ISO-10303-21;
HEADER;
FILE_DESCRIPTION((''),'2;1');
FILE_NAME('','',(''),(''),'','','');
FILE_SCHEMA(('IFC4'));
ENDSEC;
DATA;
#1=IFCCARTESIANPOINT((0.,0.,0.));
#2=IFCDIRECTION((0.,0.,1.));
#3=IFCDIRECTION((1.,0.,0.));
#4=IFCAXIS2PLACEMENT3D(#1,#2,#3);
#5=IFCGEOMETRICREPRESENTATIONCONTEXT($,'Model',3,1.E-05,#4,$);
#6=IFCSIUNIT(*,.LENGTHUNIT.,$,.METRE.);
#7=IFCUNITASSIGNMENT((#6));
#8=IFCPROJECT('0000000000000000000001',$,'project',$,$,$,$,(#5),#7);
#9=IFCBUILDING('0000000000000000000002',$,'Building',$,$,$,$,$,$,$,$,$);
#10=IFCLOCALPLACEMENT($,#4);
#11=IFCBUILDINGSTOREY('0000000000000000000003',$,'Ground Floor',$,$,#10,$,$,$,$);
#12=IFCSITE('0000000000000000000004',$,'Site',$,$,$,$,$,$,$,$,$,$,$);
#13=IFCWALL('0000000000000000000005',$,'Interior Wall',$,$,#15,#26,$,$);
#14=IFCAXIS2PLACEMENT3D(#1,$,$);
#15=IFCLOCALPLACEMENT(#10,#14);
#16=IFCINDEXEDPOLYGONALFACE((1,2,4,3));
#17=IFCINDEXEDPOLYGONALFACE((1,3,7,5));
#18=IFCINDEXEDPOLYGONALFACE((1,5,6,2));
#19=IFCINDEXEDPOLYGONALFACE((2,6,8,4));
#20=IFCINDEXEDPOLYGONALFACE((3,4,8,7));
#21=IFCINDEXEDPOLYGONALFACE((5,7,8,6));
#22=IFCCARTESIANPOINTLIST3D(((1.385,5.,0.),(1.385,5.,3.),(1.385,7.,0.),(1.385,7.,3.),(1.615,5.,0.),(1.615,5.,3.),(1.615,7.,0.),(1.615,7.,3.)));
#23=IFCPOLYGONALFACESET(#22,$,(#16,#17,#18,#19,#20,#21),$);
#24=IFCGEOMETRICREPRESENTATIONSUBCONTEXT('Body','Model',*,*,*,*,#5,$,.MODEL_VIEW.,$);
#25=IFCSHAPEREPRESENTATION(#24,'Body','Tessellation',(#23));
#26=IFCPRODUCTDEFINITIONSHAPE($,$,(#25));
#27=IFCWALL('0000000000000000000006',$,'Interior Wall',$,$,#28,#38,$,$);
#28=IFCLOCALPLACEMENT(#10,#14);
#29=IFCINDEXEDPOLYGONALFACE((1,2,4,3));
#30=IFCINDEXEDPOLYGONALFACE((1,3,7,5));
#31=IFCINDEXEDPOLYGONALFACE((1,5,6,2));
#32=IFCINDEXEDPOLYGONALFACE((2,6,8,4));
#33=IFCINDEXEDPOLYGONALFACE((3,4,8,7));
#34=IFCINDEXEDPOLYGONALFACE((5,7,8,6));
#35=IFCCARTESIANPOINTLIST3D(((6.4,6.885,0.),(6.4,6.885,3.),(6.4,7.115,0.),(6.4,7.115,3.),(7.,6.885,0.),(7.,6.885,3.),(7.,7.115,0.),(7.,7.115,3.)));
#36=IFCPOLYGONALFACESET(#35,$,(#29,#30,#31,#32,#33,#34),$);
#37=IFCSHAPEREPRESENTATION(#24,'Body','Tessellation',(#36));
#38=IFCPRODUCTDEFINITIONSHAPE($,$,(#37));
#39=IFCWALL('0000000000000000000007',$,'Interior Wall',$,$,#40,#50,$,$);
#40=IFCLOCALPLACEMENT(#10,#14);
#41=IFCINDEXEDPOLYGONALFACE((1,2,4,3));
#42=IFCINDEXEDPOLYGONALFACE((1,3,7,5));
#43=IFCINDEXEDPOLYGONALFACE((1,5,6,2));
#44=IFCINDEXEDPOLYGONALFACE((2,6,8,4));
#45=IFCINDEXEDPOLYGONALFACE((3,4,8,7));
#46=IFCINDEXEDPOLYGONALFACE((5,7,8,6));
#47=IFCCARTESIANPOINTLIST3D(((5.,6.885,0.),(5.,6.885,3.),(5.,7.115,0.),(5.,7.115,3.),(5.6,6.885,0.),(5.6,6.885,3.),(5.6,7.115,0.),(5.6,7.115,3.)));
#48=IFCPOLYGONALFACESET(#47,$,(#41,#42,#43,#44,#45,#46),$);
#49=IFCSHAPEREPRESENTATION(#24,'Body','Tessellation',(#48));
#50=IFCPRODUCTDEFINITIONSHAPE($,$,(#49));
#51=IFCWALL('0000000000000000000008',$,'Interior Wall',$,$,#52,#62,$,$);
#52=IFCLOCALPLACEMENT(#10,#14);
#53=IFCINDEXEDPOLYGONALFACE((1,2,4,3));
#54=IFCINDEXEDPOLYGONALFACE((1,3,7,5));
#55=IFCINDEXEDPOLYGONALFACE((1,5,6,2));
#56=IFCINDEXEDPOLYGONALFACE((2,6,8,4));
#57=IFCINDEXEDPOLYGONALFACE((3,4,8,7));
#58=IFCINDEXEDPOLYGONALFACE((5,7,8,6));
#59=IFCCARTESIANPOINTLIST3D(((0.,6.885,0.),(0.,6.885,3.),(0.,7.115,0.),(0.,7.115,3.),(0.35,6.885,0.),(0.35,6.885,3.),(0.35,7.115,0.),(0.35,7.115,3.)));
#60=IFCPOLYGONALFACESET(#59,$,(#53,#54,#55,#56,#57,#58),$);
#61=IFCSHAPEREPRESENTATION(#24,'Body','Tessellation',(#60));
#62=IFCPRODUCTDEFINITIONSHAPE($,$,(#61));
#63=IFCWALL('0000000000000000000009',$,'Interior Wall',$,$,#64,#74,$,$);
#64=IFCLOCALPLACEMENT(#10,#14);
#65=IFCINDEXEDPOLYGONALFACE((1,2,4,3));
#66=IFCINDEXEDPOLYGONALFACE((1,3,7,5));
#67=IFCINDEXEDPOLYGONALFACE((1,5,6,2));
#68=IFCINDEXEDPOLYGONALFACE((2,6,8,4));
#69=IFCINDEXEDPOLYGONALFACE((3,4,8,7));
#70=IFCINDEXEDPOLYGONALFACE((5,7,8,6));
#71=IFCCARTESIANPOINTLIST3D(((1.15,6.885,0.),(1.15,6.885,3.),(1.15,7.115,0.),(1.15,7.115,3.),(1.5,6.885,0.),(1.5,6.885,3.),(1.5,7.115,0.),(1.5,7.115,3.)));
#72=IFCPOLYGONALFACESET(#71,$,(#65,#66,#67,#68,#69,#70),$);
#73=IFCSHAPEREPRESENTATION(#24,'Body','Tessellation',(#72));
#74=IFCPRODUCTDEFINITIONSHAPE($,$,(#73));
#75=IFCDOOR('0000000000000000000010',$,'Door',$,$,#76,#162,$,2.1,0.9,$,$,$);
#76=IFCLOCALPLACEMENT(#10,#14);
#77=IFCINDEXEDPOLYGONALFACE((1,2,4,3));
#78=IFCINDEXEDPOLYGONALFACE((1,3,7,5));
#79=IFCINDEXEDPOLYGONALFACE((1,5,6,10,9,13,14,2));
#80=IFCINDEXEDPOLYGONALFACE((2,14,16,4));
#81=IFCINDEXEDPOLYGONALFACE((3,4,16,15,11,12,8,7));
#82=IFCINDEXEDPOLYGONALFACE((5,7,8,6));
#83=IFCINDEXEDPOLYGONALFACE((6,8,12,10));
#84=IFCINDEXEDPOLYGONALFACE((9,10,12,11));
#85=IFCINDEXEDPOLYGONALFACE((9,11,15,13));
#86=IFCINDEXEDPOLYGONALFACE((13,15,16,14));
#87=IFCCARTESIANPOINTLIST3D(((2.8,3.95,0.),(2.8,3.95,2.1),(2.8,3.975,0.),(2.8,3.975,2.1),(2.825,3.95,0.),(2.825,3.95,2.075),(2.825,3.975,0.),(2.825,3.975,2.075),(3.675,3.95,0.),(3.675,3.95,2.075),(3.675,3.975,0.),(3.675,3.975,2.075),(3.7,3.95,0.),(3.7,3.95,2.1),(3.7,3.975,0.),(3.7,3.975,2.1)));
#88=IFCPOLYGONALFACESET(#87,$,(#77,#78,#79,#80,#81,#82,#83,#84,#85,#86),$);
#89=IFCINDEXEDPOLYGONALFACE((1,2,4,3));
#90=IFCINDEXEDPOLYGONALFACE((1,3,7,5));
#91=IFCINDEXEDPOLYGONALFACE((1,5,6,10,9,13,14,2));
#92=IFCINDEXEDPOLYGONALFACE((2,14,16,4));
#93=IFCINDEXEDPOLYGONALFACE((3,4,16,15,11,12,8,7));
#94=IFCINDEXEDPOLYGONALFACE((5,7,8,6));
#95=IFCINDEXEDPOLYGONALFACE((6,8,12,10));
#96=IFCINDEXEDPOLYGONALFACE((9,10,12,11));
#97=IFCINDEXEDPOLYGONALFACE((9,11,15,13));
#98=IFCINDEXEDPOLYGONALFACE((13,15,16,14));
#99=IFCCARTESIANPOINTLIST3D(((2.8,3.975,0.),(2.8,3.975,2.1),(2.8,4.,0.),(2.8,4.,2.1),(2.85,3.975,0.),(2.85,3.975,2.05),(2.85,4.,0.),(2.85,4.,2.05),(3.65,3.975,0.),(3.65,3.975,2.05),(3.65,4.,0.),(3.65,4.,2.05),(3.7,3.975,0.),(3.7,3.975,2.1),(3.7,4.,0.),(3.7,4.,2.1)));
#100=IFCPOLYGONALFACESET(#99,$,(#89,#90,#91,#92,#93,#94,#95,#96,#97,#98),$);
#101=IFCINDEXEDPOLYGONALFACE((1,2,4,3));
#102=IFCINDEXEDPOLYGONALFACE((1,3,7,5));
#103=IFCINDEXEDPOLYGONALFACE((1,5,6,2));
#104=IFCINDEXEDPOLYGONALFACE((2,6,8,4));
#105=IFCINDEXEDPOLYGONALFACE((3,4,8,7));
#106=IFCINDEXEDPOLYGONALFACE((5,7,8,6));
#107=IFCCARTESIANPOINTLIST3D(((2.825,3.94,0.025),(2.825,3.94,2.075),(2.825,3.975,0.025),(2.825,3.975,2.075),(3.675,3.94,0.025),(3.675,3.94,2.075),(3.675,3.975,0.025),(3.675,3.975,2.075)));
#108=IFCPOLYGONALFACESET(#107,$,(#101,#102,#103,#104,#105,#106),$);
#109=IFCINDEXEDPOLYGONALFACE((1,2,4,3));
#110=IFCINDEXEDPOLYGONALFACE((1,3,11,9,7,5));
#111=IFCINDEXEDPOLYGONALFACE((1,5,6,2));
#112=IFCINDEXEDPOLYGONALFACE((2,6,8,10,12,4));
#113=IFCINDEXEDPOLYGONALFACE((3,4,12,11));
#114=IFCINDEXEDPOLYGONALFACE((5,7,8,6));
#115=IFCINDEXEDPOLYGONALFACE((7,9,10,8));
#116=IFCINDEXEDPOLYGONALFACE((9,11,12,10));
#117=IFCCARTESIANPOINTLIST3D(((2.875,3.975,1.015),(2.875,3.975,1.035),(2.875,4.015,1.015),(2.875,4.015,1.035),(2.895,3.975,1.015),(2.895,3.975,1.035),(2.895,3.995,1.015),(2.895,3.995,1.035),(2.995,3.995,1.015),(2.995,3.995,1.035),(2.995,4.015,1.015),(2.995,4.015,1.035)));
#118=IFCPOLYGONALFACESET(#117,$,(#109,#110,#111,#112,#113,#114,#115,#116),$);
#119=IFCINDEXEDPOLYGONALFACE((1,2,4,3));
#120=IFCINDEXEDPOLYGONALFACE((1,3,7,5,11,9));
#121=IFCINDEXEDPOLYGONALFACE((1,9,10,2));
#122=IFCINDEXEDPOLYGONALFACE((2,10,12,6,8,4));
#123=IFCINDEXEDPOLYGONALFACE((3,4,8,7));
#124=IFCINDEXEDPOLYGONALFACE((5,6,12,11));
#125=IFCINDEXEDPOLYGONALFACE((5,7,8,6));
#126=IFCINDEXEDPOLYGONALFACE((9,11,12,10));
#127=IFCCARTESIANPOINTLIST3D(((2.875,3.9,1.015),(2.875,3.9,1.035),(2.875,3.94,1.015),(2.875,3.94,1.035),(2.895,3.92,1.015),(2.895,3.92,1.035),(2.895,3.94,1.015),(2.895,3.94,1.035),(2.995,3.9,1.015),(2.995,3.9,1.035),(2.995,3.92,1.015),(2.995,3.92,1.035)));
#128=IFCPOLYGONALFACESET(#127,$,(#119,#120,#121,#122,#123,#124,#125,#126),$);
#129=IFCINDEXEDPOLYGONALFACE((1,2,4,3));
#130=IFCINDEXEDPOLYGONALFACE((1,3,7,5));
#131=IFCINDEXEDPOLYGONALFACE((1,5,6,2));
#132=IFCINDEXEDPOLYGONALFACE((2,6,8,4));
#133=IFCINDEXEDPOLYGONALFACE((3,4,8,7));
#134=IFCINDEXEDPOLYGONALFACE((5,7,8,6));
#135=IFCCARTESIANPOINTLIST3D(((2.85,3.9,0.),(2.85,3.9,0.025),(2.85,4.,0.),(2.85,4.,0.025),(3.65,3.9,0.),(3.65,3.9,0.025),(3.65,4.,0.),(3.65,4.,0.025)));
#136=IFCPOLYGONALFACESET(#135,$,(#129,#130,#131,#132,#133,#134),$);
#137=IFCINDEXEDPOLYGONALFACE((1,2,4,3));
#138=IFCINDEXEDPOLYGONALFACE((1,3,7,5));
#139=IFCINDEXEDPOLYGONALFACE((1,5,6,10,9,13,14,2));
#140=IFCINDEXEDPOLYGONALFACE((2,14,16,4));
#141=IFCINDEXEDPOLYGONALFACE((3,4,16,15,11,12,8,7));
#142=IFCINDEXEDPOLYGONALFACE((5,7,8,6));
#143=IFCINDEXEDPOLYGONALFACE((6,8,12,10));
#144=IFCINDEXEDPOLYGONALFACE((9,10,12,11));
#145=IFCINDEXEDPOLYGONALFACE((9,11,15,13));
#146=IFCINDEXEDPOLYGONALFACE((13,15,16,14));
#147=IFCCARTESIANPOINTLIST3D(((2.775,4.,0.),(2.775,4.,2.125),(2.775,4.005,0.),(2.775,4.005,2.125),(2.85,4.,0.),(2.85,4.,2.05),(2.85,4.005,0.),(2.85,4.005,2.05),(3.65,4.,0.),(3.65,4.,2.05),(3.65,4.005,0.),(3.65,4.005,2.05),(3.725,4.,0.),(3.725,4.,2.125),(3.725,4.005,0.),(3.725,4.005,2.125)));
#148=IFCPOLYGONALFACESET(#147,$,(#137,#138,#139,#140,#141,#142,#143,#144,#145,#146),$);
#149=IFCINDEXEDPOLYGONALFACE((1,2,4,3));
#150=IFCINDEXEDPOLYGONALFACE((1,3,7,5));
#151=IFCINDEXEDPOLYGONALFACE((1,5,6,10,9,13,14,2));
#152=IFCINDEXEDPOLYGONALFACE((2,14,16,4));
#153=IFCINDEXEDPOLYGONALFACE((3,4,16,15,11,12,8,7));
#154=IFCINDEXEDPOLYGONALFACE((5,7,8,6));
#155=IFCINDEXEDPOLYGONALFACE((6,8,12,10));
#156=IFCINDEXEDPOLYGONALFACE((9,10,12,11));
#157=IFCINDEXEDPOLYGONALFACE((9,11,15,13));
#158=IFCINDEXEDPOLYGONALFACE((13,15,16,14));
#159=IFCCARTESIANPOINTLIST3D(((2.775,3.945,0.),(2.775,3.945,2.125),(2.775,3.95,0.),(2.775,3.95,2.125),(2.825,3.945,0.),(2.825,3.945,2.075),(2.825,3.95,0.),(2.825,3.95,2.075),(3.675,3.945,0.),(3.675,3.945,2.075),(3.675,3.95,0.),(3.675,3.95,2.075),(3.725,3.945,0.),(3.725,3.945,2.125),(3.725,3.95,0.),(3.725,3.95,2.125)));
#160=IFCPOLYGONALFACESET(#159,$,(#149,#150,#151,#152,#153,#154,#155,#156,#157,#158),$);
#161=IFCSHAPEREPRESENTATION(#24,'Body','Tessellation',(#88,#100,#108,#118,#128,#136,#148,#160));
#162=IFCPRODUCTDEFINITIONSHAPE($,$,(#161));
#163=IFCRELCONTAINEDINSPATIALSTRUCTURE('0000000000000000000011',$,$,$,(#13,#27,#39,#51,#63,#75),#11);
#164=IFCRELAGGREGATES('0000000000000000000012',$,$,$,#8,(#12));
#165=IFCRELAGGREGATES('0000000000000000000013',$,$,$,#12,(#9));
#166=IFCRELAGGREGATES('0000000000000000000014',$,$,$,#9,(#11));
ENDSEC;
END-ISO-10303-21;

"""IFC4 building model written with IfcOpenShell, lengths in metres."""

from ifc_helpers import new_model, si_unit, frame, origin_with_axes, place, context, subcontext, project, spatial, line, indexed_curve, outline, extrude, element, save


model = new_model("IFC4")

# Units and contexts
model_context = context("Model", 3, precision=1e-05, world=origin_with_axes())
body_context = subcontext(model_context, "Body", "Model", "MODEL_VIEW")
ifc_project = project(units=[si_unit("LENGTHUNIT", "METRE")], contexts=[model_context])

# Site, building, storey
site = spatial("IfcSite", under=ifc_project, Name="Site")
building = spatial("IfcBuilding", under=site, Name="Building")
storey_placement = place(None, origin_with_axes())
storey = spatial("IfcBuildingStorey", under=building, at=storey_placement, Name="Ground Floor")

# Walls
wall_1_placement = place(storey_placement, frame((1.5, 7.0, 0.0), z_axis=(0.0, 0.0, 1.0), x_axis=(0.0, -1.0, 0.0)))
element("IfcWall", 1, at=wall_1_placement, inside=storey, Name="Interior Wall", context=body_context, shape_type="SweptSolid", body=[
    extrude(outline(indexed_curve([(0.0, 0.0), (0.0, 0.23), (2.0, 0.23), (2.0, 0.0), (0.0, 0.0)], self_intersect=False)), frame((0.0, -0.115, 0.0), z_axis=(0.0, 0.0, 1.0), x_axis=(1.0, 0.0, 0.0)), (0.0, 0.0, 1.0), 3.0),
])
for number, where, z_axis, x_axis, name in (
    (2, (7.0, 7.0, 0.0), (0.0, 0.0, 1.0), (-1.0, 0.0, 0.0), "Interior Wall"),
    (3, (5.6, 7.0, 0.0), (0.0, 0.0, 1.0), (-1.0, 0.0, 0.0), "Interior Wall"),
):
    element("IfcWall", number, at=place(storey_placement, frame(where, z_axis=z_axis, x_axis=x_axis)), inside=storey, Name=name, context=body_context, shape_type="SweptSolid", body=[
        extrude(outline(indexed_curve([(0.0, 0.0), (0.0, 0.23), (0.6, 0.23), (0.6, 0.0), (0.0, 0.0)], self_intersect=False)), frame((0.0, -0.115, 0.0), z_axis=(0.0, 0.0, 1.0), x_axis=(1.0, 0.0, 0.0)), (0.0, 0.0, 1.0), 3.0),
    ])
wall_2_placement = place(storey_placement, frame((0.0, 7.0, 0.0), z_axis=(0.0, 0.0, 1.0), x_axis=(1.0, 0.0, 0.0)))
element("IfcWall", 4, at=wall_2_placement, inside=storey, Name="Interior Wall", context=body_context, shape_type="SweptSolid", body=[
    extrude(outline(indexed_curve([(0.0, 0.0), (0.0, 0.23), (0.35, 0.23), (0.35, 0.0), (0.0, 0.0)], self_intersect=False)), frame((0.0, -0.115, 0.0), z_axis=(0.0, 0.0, 1.0), x_axis=(1.0, 0.0, 0.0)), (0.0, 0.0, 1.0), 3.0),
])
wall_3_placement = place(storey_placement, frame((1.15, 7.0, 0.0), z_axis=(0.0, 0.0, 1.0), x_axis=(1.0, 0.0, 0.0)))
element("IfcWall", 5, at=wall_3_placement, inside=storey, Name="Interior Wall", context=body_context, shape_type="SweptSolid", body=[
    extrude(outline(indexed_curve([(0.0, 0.0), (0.0, 0.23), (0.35, 0.23), (0.35, 0.0), (0.0, 0.0)], self_intersect=False)), frame((0.0, -0.115, 0.0), z_axis=(0.0, 0.0, 1.0), x_axis=(1.0, 0.0, 0.0)), (0.0, 0.0, 1.0), 3.0),
])

# Door
door_1_placement = place(storey_placement, frame((3.7, 4.0, 0.0), z_axis=(0.0, 0.0, 1.0), x_axis=(-1.0, 0.0, 0.0)))
element("IfcDoor", 6, at=door_1_placement, inside=storey, Name="Door", OverallHeight=2.1, OverallWidth=0.9, context=body_context, shape_type="SweptSolid", body=[
    extrude(outline(indexed_curve([(0.0, 0.0), (0.0, 2.1), (0.9, 2.1), (0.9, 0.0), (0.875, 0.0), (0.875, 2.075), (0.025, 2.075), (0.025, 0.0)], segments=[line(1, 2, 3, 4, 5, 6, 7, 8, 1)])), frame((0.0, 0.025, 0.0), z_axis=(0.0, -1.0, 0.0), x_axis=(1.0, 0.0, 0.0)), (0.0, 0.0, -1.0), 0.025),
    extrude(outline(indexed_curve([(0.0, 0.0), (0.0, 2.1), (0.9, 2.1), (0.9, 0.0), (0.85, 0.0), (0.85, 2.05), (0.05, 2.05), (0.05, 0.0)], segments=[line(1, 2, 3, 4, 5, 6, 7, 8, 1)])), frame((0.0, 0.0, 0.0), z_axis=(0.0, -1.0, 0.0), x_axis=(1.0, 0.0, 0.0)), (0.0, 0.0, -1.0), 0.025),
    extrude(outline(indexed_curve([(0.0, 0.0), (0.85, 0.0), (0.85, 0.035), (0.0, 0.035)], segments=[line(1, 2, 3, 4, 1)])), frame((0.025, 0.025, 0.025), z_axis=(0.0, 0.0, 1.0), x_axis=(1.0, 0.0, 0.0)), (0.0, 0.0, 1.0), 2.05),
    extrude(outline(indexed_curve([(0.0, 0.0), (0.0, -0.04), (-0.12, -0.04), (-0.12, -0.02), (-0.02, -0.02), (-0.02, 0.0)], segments=[line(1, 2, 3, 4, 5, 6, 1)])), frame((0.825, 0.025, 1.015), z_axis=(0.0, 0.0, 1.0), x_axis=(1.0, 0.0, 0.0)), (0.0, 0.0, 1.0), 0.02),
    extrude(outline(indexed_curve([(0.0, 0.0), (0.0, 0.04), (-0.12, 0.04), (-0.12, 0.02), (-0.02, 0.02), (-0.02, 0.0)], segments=[line(1, 2, 3, 4, 5, 6, 1)])), frame((0.825, 0.06, 1.015), z_axis=(0.0, 0.0, 1.0), x_axis=(1.0, 0.0, 0.0)), (0.0, 0.0, 1.0), 0.02),
    extrude(outline(indexed_curve([(0.0, 0.0), (0.8, 0.0), (0.8, 0.1), (0.0, 0.1)], segments=[line(1, 2, 3, 4, 1)])), frame((0.05, 0.0, 0.0), z_axis=(0.0, 0.0, 1.0), x_axis=(1.0, 0.0, 0.0)), (0.0, 0.0, 1.0), 0.025),
    extrude(outline(indexed_curve([(0.0, 0.0), (0.0, 2.125), (0.95, 2.125), (0.95, 0.0), (0.875, 0.0), (0.875, 2.05), (0.075, 2.05), (0.075, 0.0)], segments=[line(1, 2, 3, 4, 5, 6, 7, 8, 1)])), frame((-0.025, -0.005, 0.0), z_axis=(0.0, -1.0, 0.0), x_axis=(1.0, 0.0, 0.0)), (0.0, 0.0, -1.0), 0.005),
    extrude(outline(indexed_curve([(0.0, 0.0), (0.0, 2.125), (0.95, 2.125), (0.95, 0.0), (0.9, 0.0), (0.9, 2.075), (0.05, 2.075), (0.05, 0.0)], segments=[line(1, 2, 3, 4, 5, 6, 7, 8, 1)])), frame((-0.025, 0.05, 0.0), z_axis=(0.0, -1.0, 0.0), x_axis=(1.0, 0.0, 0.0)), (0.0, 0.0, -1.0), 0.005),
])

save(model, "model.ifc")
